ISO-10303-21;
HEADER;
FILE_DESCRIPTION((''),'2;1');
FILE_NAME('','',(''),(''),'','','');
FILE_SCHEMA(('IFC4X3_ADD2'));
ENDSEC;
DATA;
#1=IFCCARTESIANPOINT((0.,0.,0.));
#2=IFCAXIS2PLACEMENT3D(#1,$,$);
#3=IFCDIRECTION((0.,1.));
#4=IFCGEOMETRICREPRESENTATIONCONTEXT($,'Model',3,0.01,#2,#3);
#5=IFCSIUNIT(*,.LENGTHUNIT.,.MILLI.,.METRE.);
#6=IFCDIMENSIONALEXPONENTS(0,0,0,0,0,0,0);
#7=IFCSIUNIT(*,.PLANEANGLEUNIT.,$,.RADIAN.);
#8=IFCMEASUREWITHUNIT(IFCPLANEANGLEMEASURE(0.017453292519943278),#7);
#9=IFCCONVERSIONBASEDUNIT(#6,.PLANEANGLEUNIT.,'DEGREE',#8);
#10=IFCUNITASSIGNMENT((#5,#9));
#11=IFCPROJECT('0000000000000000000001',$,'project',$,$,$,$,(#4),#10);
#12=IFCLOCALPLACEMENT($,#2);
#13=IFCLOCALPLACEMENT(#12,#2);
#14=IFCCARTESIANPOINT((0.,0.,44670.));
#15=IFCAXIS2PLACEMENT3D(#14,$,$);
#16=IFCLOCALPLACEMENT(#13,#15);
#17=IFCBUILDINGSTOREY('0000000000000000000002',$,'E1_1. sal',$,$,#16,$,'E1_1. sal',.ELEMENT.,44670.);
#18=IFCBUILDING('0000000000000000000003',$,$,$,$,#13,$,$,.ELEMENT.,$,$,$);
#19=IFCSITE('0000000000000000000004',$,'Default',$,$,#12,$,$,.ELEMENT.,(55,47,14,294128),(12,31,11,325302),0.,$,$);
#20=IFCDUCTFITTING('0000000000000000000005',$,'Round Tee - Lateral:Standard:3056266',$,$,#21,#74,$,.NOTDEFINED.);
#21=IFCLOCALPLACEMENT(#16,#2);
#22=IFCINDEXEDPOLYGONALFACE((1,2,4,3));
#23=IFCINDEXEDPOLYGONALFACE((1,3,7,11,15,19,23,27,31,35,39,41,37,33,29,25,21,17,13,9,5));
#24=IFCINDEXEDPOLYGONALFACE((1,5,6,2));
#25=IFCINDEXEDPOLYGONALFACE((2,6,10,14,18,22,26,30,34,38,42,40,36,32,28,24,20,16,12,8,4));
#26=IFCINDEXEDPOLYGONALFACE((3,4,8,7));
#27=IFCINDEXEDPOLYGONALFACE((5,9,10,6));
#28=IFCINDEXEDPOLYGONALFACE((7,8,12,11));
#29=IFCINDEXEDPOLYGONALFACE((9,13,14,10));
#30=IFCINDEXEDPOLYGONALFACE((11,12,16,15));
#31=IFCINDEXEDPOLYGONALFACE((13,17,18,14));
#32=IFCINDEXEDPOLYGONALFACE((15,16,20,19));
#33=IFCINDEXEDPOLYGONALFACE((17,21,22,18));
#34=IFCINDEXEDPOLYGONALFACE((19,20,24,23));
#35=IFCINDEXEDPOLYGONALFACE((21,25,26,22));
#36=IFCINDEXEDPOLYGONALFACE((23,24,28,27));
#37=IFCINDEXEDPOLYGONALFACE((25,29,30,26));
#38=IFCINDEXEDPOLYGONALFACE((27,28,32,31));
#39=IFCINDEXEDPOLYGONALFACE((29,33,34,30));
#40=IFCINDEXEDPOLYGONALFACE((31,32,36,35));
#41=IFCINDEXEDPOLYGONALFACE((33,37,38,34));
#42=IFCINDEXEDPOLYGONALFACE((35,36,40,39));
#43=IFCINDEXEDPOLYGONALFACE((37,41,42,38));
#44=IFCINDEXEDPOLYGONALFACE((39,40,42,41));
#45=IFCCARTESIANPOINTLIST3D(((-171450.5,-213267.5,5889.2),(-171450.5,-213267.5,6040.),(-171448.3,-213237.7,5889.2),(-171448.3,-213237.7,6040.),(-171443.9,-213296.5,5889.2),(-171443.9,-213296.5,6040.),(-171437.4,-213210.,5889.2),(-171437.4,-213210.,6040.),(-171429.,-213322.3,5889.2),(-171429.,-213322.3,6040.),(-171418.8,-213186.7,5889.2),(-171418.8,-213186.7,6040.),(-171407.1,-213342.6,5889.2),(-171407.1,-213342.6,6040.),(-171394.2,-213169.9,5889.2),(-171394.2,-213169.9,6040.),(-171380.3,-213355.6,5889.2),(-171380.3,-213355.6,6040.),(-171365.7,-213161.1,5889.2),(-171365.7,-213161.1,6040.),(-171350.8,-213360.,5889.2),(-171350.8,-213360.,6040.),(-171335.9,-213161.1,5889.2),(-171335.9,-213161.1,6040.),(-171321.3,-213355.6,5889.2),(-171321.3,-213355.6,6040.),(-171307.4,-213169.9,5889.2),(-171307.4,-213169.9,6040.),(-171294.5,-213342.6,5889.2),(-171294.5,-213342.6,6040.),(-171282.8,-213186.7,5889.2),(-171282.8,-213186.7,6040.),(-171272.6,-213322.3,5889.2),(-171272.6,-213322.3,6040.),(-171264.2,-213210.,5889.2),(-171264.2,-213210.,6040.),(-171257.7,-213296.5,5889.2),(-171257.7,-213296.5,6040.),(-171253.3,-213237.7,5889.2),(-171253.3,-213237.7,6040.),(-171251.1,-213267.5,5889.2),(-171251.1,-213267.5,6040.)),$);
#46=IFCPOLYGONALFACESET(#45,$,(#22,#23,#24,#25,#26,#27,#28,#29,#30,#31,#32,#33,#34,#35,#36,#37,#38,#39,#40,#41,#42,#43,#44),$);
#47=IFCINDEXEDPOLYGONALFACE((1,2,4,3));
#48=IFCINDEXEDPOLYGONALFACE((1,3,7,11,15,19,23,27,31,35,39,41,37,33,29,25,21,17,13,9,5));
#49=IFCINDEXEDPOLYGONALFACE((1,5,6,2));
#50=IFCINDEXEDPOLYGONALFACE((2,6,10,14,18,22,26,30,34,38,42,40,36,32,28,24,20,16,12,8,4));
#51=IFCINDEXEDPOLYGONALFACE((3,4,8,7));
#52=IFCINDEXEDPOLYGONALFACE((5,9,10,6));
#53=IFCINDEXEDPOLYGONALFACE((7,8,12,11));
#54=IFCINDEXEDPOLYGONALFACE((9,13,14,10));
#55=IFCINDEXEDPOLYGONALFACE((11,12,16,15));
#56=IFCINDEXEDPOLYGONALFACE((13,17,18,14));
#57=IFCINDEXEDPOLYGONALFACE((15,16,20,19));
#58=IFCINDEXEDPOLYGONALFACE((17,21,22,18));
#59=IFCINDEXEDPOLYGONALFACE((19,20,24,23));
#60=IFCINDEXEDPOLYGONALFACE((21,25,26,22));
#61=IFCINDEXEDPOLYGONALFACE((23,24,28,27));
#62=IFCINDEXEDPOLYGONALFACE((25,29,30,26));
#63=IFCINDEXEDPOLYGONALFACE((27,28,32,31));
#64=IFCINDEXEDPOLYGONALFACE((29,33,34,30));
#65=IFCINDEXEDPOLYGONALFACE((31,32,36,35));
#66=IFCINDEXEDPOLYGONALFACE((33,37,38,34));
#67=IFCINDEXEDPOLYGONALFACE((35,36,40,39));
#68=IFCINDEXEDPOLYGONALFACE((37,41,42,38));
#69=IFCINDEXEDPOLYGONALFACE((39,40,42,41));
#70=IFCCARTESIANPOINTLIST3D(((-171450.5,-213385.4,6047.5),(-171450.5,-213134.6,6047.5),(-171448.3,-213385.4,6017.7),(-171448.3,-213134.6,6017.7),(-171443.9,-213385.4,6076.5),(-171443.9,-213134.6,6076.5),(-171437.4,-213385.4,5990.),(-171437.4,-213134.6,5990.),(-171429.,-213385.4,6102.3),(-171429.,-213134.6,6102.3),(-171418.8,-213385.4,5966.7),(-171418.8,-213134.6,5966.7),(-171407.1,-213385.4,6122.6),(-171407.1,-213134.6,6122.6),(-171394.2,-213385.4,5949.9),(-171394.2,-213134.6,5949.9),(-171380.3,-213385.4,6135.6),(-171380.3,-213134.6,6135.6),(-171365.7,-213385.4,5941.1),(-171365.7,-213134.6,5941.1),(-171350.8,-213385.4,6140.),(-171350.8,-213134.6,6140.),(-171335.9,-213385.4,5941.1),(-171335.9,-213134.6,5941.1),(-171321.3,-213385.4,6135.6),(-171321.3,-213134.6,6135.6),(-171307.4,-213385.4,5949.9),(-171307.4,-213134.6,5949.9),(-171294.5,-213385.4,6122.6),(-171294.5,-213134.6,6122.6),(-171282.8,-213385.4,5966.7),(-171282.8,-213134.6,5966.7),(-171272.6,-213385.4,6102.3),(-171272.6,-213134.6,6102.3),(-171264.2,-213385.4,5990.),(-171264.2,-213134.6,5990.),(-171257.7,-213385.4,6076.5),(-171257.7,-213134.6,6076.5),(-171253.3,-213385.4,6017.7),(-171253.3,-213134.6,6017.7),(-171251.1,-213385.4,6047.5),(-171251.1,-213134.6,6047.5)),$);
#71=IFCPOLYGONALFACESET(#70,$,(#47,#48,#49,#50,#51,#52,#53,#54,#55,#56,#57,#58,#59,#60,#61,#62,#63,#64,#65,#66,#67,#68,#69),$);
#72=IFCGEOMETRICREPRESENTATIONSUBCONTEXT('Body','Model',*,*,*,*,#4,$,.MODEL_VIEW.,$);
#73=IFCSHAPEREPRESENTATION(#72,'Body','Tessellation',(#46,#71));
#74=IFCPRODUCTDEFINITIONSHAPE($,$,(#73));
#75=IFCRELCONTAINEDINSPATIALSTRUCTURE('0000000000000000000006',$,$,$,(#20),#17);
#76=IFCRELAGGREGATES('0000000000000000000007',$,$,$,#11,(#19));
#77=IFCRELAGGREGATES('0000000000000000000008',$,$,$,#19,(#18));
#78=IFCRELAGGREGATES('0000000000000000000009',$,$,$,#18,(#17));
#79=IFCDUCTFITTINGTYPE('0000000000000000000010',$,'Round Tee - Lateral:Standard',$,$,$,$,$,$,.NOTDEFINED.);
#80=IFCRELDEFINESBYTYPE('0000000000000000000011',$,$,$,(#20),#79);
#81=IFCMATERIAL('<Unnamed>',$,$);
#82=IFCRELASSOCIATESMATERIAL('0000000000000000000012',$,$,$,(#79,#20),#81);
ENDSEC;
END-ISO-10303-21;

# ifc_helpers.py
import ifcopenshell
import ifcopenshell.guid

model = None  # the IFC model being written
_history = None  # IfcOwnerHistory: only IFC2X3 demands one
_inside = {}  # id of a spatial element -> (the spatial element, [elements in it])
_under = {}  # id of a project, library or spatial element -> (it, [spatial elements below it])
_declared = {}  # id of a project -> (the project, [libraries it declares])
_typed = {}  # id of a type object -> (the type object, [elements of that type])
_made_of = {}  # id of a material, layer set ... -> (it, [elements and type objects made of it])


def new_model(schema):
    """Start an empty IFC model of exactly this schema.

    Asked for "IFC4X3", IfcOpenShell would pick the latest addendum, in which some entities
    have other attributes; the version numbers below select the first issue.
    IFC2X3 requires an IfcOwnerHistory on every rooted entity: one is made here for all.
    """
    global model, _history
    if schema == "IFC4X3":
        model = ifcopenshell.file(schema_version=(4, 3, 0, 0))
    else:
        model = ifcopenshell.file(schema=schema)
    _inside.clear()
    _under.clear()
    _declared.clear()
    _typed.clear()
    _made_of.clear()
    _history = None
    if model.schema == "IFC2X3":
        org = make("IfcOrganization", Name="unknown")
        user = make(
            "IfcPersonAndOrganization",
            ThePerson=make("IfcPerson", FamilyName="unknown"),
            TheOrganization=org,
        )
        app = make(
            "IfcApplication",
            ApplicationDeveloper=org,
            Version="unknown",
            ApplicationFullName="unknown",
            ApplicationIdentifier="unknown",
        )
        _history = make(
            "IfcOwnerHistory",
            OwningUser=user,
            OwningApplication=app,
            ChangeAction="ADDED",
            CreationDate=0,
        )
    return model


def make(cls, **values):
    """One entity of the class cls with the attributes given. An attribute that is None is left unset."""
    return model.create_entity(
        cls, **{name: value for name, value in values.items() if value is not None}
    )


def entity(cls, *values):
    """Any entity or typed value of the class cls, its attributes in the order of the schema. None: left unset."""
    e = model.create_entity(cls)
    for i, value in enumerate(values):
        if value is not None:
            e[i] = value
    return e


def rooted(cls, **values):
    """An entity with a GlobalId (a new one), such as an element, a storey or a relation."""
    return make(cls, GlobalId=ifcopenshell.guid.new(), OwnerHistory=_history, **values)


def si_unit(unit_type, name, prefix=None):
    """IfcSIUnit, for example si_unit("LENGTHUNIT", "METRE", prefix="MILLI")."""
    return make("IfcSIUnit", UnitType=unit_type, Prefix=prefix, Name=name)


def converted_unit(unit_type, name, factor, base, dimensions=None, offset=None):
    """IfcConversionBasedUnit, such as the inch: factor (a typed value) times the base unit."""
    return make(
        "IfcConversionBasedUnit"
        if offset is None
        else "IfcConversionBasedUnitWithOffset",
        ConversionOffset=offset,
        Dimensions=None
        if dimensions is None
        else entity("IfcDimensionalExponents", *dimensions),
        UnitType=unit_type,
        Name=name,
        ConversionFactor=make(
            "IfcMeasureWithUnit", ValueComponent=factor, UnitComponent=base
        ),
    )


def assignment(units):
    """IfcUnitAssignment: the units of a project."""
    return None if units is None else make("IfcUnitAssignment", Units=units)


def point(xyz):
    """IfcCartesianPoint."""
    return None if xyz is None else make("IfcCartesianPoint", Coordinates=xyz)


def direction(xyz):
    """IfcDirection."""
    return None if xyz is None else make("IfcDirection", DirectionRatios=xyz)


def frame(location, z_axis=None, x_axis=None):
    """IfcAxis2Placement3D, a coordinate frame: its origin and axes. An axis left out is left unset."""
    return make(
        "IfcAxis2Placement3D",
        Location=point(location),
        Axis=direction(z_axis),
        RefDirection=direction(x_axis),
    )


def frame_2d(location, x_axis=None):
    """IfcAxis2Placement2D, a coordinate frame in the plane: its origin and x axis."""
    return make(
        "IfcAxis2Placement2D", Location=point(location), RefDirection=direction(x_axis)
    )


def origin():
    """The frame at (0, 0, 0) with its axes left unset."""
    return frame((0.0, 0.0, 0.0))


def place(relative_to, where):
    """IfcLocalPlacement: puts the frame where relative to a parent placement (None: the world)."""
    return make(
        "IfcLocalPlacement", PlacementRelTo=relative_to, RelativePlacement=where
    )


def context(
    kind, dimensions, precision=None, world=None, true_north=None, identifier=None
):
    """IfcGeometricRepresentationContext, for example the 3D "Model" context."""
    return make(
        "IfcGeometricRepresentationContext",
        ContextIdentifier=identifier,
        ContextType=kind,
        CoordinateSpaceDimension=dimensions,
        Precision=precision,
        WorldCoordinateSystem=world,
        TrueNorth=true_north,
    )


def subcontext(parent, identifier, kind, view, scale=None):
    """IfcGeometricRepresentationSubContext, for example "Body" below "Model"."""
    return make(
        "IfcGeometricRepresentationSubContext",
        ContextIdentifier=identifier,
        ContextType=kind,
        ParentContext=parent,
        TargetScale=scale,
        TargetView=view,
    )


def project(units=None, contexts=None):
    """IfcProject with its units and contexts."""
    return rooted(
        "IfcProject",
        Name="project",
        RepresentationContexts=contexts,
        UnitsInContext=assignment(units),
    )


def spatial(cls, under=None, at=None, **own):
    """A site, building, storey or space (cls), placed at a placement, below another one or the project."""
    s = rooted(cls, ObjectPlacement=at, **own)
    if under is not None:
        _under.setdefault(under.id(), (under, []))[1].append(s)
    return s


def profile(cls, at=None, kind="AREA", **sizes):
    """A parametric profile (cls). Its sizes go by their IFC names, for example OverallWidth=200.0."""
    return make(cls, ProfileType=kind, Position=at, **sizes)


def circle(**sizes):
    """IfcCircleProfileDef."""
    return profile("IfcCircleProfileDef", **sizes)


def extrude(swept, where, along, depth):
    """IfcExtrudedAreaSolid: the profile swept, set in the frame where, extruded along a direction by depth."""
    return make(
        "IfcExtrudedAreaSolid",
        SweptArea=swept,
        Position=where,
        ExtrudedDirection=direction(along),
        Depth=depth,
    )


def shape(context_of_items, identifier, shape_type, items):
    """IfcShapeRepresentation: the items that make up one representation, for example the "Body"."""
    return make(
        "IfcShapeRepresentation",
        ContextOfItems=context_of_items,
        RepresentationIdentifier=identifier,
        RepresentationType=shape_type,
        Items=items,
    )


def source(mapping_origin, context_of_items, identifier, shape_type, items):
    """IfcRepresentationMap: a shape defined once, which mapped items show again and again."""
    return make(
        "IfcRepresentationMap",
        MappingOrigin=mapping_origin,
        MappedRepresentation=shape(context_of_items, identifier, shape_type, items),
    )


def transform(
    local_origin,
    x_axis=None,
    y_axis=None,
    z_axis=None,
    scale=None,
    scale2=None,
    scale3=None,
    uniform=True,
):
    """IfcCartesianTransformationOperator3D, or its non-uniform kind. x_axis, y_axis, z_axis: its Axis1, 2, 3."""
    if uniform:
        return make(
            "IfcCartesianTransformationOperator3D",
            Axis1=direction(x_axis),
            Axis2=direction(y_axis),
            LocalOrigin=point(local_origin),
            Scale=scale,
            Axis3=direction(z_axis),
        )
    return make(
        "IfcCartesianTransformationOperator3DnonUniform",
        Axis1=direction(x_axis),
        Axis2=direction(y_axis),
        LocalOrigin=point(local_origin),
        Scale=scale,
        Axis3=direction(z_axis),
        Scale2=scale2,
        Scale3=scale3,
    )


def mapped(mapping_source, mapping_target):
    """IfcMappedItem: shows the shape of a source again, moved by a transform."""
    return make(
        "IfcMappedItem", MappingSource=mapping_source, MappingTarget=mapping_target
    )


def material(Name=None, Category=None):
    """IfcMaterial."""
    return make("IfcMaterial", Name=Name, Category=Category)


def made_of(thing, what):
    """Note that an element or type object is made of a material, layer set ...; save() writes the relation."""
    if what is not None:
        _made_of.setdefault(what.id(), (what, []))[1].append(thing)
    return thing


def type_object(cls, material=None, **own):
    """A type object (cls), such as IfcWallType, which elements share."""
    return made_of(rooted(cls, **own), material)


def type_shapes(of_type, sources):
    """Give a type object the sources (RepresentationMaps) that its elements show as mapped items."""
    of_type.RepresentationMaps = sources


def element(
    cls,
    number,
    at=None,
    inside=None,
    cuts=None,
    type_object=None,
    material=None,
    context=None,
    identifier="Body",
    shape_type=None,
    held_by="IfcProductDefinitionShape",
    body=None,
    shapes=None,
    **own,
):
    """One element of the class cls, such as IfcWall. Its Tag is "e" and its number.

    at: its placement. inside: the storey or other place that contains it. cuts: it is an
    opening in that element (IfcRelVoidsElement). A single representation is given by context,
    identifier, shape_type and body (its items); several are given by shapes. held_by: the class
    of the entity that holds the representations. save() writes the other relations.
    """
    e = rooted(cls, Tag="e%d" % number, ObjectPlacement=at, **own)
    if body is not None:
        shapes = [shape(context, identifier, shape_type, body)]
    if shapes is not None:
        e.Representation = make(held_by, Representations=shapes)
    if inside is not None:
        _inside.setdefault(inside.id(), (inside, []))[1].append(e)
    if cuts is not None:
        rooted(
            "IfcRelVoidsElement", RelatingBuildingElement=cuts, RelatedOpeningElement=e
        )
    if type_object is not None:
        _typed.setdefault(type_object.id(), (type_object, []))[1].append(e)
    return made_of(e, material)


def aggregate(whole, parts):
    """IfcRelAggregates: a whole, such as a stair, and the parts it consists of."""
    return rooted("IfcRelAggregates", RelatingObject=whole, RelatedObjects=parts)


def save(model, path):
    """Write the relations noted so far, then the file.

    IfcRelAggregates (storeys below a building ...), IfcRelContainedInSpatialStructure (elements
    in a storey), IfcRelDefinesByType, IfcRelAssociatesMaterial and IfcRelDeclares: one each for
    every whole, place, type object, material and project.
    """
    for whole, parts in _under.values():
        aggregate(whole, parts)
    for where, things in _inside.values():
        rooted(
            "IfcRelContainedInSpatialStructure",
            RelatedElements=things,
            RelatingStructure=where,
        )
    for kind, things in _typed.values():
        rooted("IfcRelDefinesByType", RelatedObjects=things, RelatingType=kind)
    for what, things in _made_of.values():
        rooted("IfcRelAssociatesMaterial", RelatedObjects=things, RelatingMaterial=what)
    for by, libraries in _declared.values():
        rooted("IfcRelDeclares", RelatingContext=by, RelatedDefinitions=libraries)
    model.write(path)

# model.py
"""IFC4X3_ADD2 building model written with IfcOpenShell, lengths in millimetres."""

from ifc_helpers import new_model, entity, si_unit, converted_unit, direction, frame, frame_2d, origin, place, context, subcontext, project, spatial, circle, extrude, source, transform, mapped, material, type_object, type_shapes, element, save


model = new_model("IFC4X3_ADD2")

# Units and contexts
model_context = context("Model", 3, precision=0.01, world=origin(), true_north=direction((0.0, 1.0)))
body_context = subcontext(model_context, "Body", "Model", "MODEL_VIEW")
ifc_project = project(units=[si_unit("LENGTHUNIT", "METRE", prefix="MILLI"), converted_unit("PLANEANGLEUNIT", "DEGREE", entity("IfcPlaneAngleMeasure", 0.017453292519943278), si_unit("PLANEANGLEUNIT", "RADIAN"), dimensions=[0, 0, 0, 0, 0, 0, 0])], contexts=[model_context])

# Site, building, storey
site_placement = place(None, origin())
site = spatial("IfcSite", under=ifc_project, at=site_placement, Name="Default", CompositionType="ELEMENT", RefLatitude=(55, 47, 14, 294128), RefLongitude=(12, 31, 11, 325302), RefElevation=0.0)
building_placement = place(site_placement, origin())
building = spatial("IfcBuilding", under=site, at=building_placement, CompositionType="ELEMENT")
storey_placement = place(building_placement, frame((0.0, 0.0, 44670.0)))
storey = spatial("IfcBuildingStorey", under=building, at=storey_placement, Name="E1_1. sal", LongName="E1_1. sal", CompositionType="ELEMENT", Elevation=44670.0)

# Shared definitions
ifc_material_1 = material(Name="<Unnamed>")

# Duct fitting
duct_fitting_type = type_object("IfcDuctFittingType", Name="Round Tee - Lateral:Standard", PredefinedType="NOTDEFINED", material=ifc_material_1)
shared_shape_1 = source(origin(), body_context, "Body", "SweptSolid", [
    extrude(circle(Radius=100.0, at=frame_2d((0.0, 0.0), x_axis=(1.0, 0.0))), frame((0.0, -150.8, 0.0), z_axis=(0.0, 1.0, 0.0), x_axis=(1.0, 0.0, 0.0)), (0.0, 0.0, 1.0), 150.8),
    extrude(circle(Radius=100.0, at=frame_2d((0.0, 0.0), x_axis=(1.0, 0.0))), frame((-125.4, 0.0, 0.0), z_axis=(1.0, 0.0, 0.0), x_axis=(0.0, 1.0, 0.0)), (0.0, 0.0, 1.0), 250.8),
])
type_shapes(duct_fitting_type, [shared_shape_1])
duct_fitting_placement = place(storey_placement, frame((-171350.8, -213260.0, 6040.0), z_axis=(-1.0, 0.0, 0.0), x_axis=(0.0, -1.0, 0.0)))
element("IfcDuctFitting", 1, at=duct_fitting_placement, inside=storey, type_object=duct_fitting_type, material=ifc_material_1, Name="Round Tee - Lateral:Standard:3056266", PredefinedType="NOTDEFINED", context=body_context, shape_type="MappedRepresentation", body=[
    mapped(shared_shape_1, transform((0.0, 0.0, 0.0), scale=1.0)),
])

save(model, "model.ifc")
